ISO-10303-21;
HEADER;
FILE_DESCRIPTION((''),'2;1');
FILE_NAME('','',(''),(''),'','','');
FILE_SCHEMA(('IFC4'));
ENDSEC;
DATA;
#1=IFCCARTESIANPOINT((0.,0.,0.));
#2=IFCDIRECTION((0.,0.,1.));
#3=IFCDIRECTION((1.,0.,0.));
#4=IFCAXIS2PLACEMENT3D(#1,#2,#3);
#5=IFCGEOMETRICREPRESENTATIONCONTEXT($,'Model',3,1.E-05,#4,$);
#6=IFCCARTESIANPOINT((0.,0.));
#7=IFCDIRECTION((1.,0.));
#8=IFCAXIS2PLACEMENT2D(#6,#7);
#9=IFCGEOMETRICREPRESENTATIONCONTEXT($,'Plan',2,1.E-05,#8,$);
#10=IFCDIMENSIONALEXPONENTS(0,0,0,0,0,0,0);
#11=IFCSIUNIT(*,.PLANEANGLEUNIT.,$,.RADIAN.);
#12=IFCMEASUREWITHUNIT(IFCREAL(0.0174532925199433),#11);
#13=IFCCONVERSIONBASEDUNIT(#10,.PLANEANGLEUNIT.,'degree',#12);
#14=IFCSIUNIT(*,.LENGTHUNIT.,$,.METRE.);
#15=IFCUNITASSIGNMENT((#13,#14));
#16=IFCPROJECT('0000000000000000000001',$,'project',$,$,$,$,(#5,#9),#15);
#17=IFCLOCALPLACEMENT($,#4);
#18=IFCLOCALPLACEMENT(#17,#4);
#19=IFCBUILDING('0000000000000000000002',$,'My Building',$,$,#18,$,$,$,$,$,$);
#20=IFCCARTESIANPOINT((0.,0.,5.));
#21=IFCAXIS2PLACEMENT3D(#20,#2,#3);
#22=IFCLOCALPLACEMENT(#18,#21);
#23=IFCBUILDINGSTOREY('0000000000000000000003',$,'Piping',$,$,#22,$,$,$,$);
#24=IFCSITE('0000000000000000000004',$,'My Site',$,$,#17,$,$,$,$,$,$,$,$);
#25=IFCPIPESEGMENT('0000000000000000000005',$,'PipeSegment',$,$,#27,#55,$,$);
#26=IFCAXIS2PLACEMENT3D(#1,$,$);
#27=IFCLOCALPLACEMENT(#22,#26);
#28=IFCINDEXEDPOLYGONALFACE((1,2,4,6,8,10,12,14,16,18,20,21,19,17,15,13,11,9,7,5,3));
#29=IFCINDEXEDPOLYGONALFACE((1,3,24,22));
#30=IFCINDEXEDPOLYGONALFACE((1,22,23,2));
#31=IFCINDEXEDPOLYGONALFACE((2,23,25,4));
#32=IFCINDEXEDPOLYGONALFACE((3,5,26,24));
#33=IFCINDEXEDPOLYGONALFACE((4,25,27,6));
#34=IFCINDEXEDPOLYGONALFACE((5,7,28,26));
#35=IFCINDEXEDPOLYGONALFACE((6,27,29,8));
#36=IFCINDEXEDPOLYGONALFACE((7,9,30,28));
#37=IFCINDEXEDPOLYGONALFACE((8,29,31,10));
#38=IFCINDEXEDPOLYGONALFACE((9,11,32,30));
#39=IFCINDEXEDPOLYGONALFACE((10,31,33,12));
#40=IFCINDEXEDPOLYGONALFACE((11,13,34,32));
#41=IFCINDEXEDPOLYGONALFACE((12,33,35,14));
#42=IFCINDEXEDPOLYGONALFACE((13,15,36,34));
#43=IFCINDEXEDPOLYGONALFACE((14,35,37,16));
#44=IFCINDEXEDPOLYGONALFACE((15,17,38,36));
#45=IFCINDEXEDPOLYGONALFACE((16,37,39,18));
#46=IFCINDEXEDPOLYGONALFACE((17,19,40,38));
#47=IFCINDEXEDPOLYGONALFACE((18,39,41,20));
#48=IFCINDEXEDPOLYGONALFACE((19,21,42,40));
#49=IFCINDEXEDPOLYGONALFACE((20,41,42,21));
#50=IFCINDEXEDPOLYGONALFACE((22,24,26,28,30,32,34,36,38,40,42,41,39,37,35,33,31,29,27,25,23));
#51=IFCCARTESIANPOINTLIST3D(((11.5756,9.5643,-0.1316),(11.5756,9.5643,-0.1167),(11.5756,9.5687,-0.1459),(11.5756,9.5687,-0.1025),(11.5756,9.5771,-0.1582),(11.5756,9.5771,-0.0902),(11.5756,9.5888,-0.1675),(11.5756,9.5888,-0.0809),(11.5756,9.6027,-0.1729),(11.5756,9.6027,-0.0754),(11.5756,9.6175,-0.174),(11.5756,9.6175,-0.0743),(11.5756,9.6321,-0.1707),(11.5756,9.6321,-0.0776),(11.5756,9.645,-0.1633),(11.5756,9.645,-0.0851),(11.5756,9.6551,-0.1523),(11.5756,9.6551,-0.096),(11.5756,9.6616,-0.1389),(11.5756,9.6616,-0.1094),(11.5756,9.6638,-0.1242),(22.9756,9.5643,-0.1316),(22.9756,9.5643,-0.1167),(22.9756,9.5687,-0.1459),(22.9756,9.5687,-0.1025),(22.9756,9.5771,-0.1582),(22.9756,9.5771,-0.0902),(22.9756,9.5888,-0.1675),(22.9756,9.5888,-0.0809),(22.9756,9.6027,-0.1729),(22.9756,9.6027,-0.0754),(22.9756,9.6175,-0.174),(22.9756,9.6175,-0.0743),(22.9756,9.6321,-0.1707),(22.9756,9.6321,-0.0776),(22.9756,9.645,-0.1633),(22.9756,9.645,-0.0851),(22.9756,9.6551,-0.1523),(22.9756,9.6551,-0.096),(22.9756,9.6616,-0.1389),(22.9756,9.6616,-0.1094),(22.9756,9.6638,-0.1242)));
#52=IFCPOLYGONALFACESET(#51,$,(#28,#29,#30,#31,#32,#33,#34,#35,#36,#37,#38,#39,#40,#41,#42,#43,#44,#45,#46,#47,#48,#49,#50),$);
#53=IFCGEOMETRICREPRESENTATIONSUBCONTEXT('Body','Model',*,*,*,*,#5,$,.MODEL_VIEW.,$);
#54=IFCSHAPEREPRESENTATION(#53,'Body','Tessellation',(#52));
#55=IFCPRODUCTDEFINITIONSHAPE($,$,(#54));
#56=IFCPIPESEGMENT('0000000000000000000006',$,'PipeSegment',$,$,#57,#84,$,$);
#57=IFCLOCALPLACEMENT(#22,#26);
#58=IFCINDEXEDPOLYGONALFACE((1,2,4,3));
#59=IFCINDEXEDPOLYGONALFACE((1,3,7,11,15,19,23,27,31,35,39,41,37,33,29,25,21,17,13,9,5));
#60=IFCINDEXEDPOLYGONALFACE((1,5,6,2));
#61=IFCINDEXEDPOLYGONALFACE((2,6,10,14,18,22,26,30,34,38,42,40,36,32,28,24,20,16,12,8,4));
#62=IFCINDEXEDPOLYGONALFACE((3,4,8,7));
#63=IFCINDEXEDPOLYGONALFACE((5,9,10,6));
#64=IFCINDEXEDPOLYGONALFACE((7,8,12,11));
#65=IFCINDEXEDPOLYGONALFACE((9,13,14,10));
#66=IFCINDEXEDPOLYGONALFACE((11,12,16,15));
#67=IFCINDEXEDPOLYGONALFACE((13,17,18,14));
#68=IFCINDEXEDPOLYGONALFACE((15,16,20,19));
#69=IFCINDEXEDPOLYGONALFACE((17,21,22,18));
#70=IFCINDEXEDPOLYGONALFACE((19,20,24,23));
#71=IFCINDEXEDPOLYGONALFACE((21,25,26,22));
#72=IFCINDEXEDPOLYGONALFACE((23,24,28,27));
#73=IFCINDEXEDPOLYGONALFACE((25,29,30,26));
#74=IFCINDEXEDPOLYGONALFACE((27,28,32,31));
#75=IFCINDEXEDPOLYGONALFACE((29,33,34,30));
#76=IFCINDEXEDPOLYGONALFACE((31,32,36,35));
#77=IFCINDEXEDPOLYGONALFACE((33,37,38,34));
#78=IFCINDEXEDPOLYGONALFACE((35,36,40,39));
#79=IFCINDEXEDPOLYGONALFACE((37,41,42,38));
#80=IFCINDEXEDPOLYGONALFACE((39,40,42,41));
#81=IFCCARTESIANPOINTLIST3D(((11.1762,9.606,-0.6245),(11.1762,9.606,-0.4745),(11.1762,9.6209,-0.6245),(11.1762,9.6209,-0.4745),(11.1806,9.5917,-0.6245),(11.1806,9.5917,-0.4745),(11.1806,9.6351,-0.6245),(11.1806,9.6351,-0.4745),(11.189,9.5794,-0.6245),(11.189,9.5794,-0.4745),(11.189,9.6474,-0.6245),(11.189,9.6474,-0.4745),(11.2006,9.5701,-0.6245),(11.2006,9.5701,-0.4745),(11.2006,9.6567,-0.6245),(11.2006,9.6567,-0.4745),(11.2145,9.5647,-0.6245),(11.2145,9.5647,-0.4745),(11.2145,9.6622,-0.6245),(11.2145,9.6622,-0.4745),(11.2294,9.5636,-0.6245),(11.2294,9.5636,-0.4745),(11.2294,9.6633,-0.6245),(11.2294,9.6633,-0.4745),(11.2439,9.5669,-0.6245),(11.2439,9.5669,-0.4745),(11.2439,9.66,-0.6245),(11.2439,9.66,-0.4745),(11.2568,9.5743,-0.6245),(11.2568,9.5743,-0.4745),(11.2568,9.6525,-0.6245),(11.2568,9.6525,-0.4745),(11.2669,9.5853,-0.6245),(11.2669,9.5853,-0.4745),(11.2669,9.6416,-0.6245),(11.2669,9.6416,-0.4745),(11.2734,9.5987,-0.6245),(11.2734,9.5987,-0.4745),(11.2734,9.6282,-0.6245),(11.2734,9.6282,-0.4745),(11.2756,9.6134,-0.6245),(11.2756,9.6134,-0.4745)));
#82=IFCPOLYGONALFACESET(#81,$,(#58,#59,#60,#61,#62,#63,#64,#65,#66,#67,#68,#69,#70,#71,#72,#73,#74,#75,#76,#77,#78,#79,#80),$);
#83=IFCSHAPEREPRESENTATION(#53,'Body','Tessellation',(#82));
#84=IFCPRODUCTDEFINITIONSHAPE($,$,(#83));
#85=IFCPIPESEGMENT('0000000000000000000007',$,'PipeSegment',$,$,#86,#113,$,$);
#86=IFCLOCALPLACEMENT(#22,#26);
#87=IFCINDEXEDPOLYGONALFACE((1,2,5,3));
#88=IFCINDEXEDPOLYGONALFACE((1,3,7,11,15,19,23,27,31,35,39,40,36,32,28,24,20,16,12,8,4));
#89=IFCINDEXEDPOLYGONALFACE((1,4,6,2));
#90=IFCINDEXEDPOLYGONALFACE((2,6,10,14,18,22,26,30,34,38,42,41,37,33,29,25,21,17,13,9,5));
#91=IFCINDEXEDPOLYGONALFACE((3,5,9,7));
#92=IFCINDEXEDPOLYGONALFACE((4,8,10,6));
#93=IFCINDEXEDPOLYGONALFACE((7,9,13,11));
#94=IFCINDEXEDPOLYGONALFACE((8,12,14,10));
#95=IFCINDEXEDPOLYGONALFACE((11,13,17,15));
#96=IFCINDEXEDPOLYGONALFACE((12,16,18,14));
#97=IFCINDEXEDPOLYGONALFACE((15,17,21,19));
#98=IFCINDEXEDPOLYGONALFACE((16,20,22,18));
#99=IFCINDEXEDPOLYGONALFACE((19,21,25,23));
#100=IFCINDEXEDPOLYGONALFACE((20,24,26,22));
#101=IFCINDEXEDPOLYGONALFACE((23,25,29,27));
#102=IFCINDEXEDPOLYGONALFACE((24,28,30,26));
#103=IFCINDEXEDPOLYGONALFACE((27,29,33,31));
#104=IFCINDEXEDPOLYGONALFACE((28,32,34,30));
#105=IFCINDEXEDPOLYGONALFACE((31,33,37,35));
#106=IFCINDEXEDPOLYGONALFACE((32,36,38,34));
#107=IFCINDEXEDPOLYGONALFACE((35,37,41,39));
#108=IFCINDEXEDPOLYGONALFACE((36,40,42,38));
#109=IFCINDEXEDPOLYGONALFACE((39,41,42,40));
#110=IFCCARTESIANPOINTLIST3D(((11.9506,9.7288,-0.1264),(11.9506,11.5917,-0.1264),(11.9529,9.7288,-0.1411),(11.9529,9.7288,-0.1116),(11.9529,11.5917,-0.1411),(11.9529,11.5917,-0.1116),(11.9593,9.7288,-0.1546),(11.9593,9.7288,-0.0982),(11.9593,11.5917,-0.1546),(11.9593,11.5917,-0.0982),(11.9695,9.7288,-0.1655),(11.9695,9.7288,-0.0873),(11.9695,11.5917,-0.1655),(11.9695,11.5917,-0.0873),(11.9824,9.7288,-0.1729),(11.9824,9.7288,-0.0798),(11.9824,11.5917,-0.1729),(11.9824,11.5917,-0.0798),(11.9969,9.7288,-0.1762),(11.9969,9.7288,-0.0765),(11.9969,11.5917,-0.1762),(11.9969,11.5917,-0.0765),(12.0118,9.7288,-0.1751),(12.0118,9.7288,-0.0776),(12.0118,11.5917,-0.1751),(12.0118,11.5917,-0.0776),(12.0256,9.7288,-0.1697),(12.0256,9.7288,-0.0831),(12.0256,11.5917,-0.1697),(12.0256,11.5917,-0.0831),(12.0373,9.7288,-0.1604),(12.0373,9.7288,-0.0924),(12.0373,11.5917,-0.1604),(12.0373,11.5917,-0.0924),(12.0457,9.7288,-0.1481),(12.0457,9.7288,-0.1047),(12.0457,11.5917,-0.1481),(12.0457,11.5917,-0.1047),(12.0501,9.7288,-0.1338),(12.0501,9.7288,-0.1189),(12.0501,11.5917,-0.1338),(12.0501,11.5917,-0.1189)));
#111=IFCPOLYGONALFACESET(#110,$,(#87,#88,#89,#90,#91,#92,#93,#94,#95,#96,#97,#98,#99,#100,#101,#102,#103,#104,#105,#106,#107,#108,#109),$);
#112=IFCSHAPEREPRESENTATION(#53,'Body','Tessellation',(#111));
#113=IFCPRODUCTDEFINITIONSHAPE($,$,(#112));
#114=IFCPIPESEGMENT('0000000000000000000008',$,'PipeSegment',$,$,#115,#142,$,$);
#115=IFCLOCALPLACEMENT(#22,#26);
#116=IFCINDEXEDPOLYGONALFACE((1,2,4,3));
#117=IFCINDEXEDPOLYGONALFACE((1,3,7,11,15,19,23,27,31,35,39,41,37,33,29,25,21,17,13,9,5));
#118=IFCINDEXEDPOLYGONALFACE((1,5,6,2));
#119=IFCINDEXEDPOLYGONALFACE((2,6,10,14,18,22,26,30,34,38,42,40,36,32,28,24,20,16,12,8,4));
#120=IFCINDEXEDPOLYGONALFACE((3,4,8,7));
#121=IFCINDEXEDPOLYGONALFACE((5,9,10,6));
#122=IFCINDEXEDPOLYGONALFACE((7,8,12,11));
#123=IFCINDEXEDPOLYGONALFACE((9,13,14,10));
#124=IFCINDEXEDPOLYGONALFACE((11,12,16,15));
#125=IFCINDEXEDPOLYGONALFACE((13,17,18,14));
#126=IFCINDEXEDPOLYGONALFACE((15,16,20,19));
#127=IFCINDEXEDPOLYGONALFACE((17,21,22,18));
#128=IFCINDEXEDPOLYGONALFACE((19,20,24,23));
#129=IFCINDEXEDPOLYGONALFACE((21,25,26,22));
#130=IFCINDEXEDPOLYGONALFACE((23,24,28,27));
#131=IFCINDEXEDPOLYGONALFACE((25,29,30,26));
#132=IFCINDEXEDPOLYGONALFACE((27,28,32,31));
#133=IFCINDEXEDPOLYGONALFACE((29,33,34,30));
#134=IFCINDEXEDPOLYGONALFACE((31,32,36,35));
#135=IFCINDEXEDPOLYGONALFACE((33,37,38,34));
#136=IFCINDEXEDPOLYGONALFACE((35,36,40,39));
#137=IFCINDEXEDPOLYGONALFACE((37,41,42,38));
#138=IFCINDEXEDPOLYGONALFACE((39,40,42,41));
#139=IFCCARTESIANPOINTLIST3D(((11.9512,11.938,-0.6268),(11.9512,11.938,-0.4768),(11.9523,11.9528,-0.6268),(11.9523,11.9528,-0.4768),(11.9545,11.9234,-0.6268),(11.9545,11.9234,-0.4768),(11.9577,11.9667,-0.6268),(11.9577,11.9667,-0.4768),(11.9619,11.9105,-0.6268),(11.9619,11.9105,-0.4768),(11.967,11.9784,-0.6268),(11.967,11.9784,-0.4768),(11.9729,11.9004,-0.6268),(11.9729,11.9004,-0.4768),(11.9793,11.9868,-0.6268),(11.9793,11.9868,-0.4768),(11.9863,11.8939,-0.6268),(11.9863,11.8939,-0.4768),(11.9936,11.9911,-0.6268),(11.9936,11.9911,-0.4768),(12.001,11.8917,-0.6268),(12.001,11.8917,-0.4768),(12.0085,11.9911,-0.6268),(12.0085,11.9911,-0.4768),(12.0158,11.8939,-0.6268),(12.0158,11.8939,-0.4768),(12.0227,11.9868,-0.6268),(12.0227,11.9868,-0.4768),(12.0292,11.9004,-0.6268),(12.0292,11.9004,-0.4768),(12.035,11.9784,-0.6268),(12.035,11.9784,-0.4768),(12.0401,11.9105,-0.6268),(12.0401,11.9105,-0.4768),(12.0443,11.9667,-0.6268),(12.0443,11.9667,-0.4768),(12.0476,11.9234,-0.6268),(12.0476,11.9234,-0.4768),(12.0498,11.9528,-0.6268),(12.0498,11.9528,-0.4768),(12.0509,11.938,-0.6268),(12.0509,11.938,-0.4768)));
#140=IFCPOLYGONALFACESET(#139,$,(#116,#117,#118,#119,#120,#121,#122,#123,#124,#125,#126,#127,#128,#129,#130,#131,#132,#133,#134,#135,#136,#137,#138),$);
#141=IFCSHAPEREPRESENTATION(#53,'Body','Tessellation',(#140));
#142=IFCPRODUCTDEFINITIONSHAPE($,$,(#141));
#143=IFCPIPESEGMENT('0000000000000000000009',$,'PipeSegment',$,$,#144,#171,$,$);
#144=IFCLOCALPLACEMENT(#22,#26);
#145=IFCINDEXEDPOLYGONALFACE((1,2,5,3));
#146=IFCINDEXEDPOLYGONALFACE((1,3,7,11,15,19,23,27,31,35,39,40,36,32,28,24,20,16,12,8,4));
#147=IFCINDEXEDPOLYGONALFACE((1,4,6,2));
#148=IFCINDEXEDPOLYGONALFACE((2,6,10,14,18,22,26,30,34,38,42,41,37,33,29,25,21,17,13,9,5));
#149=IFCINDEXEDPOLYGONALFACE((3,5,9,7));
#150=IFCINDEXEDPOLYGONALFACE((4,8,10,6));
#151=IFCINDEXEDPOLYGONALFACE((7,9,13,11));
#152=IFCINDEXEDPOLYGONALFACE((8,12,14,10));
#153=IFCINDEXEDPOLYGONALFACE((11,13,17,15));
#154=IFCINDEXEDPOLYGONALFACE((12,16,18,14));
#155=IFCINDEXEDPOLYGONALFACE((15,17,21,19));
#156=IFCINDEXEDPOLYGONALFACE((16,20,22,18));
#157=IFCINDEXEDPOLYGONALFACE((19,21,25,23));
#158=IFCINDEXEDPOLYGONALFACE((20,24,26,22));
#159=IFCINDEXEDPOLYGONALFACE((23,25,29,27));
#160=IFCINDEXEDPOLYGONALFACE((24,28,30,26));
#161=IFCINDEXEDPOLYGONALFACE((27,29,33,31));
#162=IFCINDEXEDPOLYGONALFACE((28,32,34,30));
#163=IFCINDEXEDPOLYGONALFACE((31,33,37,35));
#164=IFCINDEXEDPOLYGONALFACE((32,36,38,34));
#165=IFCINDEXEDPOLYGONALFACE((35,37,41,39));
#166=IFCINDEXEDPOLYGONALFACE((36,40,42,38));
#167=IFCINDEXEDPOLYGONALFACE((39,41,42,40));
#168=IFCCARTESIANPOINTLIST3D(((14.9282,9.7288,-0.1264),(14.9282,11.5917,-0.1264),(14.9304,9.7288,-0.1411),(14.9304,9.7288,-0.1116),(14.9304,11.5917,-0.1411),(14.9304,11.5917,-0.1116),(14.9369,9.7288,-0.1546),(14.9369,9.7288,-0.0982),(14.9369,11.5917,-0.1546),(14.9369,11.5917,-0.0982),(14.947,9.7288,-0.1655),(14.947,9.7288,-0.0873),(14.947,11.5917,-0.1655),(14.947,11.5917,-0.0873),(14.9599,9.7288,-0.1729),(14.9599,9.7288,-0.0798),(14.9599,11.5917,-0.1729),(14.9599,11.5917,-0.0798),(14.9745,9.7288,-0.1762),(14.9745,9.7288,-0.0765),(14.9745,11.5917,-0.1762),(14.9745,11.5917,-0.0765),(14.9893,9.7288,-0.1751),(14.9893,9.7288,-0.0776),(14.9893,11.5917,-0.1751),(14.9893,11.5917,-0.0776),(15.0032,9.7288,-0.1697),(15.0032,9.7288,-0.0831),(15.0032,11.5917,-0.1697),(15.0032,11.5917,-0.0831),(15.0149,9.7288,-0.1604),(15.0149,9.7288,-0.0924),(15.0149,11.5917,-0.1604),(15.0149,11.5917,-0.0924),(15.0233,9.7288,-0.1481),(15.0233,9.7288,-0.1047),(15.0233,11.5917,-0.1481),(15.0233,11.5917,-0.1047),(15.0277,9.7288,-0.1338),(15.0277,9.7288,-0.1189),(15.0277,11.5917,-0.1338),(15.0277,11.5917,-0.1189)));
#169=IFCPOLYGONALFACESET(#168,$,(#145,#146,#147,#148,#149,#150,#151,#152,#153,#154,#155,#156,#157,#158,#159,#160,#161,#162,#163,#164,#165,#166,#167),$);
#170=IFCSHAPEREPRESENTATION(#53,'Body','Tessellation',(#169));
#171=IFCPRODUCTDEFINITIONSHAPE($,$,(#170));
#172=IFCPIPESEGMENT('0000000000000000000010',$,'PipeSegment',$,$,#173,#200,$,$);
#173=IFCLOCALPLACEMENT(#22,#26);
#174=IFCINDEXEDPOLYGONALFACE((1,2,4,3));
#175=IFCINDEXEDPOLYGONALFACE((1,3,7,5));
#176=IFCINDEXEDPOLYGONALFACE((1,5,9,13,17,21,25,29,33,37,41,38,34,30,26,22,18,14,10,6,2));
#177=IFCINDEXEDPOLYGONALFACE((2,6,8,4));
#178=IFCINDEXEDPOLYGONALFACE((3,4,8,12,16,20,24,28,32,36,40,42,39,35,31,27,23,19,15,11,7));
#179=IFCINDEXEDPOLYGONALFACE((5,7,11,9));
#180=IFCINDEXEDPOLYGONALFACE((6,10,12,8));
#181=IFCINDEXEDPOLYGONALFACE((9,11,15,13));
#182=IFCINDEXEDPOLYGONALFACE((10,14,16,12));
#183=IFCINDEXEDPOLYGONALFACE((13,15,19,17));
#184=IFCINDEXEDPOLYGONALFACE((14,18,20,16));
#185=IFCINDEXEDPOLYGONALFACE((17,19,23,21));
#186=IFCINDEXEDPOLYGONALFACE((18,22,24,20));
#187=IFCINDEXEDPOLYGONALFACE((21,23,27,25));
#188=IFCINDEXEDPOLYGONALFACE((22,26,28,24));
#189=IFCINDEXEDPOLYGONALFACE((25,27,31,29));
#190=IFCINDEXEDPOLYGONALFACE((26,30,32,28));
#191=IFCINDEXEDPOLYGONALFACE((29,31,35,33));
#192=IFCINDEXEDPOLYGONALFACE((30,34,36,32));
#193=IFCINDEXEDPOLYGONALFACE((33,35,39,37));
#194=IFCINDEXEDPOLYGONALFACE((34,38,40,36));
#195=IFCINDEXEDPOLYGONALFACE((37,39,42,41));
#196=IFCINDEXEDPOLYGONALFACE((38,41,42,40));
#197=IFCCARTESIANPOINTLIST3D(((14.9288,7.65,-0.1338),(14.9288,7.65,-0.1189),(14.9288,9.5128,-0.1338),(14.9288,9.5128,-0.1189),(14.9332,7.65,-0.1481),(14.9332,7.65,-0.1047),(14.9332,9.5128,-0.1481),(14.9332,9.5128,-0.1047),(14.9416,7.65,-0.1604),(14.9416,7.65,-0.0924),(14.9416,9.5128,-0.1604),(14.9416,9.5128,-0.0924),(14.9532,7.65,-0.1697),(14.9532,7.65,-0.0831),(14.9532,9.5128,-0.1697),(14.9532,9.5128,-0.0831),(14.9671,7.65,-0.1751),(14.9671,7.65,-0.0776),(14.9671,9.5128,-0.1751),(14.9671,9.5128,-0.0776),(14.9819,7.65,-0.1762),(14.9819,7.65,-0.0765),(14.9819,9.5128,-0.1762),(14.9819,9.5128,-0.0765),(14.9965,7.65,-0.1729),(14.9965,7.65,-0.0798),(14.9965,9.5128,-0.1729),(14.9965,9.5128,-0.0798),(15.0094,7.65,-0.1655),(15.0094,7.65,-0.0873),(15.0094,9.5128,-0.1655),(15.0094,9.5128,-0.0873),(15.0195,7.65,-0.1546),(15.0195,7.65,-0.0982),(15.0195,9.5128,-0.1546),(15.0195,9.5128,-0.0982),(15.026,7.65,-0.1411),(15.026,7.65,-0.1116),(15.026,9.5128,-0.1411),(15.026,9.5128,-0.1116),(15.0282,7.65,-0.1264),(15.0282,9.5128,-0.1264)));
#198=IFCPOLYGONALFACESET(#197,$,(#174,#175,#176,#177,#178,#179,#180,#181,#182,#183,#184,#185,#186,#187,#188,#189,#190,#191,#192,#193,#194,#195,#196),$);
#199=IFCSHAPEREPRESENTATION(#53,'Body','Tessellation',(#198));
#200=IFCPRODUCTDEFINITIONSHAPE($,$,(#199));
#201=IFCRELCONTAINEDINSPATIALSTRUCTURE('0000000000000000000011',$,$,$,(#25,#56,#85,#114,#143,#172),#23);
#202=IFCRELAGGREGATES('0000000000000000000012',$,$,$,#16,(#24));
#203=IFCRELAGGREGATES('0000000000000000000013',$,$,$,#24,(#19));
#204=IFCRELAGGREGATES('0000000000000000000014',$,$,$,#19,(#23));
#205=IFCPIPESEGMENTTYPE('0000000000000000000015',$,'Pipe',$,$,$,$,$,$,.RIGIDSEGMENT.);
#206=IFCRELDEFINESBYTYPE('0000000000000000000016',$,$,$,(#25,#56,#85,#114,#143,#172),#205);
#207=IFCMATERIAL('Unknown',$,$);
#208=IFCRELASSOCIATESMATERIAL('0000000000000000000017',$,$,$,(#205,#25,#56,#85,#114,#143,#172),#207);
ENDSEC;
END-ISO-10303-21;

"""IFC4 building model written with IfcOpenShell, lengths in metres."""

from ifc_helpers import new_model, entity, si_unit, converted_unit, frame, origin_with_axes, origin_2d_with_axis, place, context, subcontext, project, spatial, circle, extrude, material, material_profile, profile_set, profile_usage, type_object, element, save


model = new_model("IFC4")

# Units and contexts
model_context = context("Model", 3, precision=1e-05, world=origin_with_axes())
plan_context = context("Plan", 2, precision=1e-05, world=origin_2d_with_axis())
body_context = subcontext(model_context, "Body", "Model", "MODEL_VIEW")
ifc_project = project(units=[converted_unit("PLANEANGLEUNIT", "degree", entity("IfcReal", 0.0174532925199433), si_unit("PLANEANGLEUNIT", "RADIAN"), dimensions=[0, 0, 0, 0, 0, 0, 0]), si_unit("LENGTHUNIT", "METRE")], contexts=[model_context, plan_context])

# Site, building, storey
site_placement = place(None, origin_with_axes())
site = spatial("IfcSite", under=ifc_project, at=site_placement, Name="My Site")
building_placement = place(site_placement, origin_with_axes())
building = spatial("IfcBuilding", under=site, at=building_placement, Name="My Building")
storey_placement = place(building_placement, frame((0.0, 0.0, 5.0), z_axis=(0.0, 0.0, 1.0), x_axis=(1.0, 0.0, 0.0)))
storey = spatial("IfcBuildingStorey", under=building, at=storey_placement, Name="Piping")

# Pipe segments
ifc_material = material(Name="Unknown")
ifc_material_profile_1 = material_profile(ifc_material, circle(Radius=0.05))
ifc_profile_set_1 = profile_set([ifc_material_profile_1])
pipe_segment_type = type_object("IfcPipeSegmentType", Name="Pipe", PredefinedType="RIGIDSEGMENT", material=ifc_profile_set_1)
ifc_profile_usage_1 = profile_usage(ifc_profile_set_1, cardinal=5)
pipe_segment_1_placement = place(storey_placement, frame((11.5756, 9.6138, -0.1242), z_axis=(1.0, 0.0, 0.0), x_axis=(0.0, 1.0, 0.0)))
element("IfcPipeSegment", 1, at=pipe_segment_1_placement, inside=storey, type_object=pipe_segment_type, material=ifc_profile_usage_1, Name="PipeSegment", context=body_context, shape_type="SweptSolid", body=[
    extrude(circle(Radius=0.05), origin_with_axes(), (0.0, 0.0, 1.0), 11.4),
])
ifc_profile_usage_2 = profile_usage(ifc_profile_set_1, cardinal=5)
pipe_segment_2_placement = place(storey_placement, frame((11.2256, 9.6134, -0.4745), z_axis=(0.0, 0.0, -1.0), x_axis=(1.0, 0.0, 0.0)))
element("IfcPipeSegment", 2, at=pipe_segment_2_placement, inside=storey, type_object=pipe_segment_type, material=ifc_profile_usage_2, Name="PipeSegment", context=body_context, shape_type="SweptSolid", body=[
    extrude(circle(Radius=0.05), origin_with_axes(), (0.0, 0.0, 1.0), 0.15),
])
ifc_profile_usage_3 = profile_usage(ifc_profile_set_1, cardinal=5)
pipe_segment_3_placement = place(storey_placement, frame((12.0006, 9.7288, -0.1264), z_axis=(0.0, 1.0, 0.0), x_axis=(-1.0, 0.0, 0.0)))
element("IfcPipeSegment", 3, at=pipe_segment_3_placement, inside=storey, type_object=pipe_segment_type, material=ifc_profile_usage_3, Name="PipeSegment", context=body_context, shape_type="SweptSolid", body=[
    extrude(circle(Radius=0.05), origin_with_axes(), (0.0, 0.0, 1.0), 1.8629),
])
ifc_profile_usage_4 = profile_usage(ifc_profile_set_1, cardinal=5)
pipe_segment_4_placement = place(storey_placement, frame((12.001, 11.9417, -0.4768), z_axis=(0.0, 0.0, -1.0), x_axis=(-0.000053, -1.0, 0.0)))
element("IfcPipeSegment", 4, at=pipe_segment_4_placement, inside=storey, type_object=pipe_segment_type, material=ifc_profile_usage_4, Name="PipeSegment", context=body_context, shape_type="SweptSolid", body=[
    extrude(circle(Radius=0.05), origin_with_axes(), (0.0, 0.0, 1.0), 0.15),
])
ifc_profile_usage_5 = profile_usage(ifc_profile_set_1, cardinal=5)
pipe_segment_5_placement = place(storey_placement, frame((14.9782, 9.7288, -0.1264), z_axis=(0.0, 1.0, 0.0), x_axis=(-1.0, 0.0, 0.0)))
element("IfcPipeSegment", 5, at=pipe_segment_5_placement, inside=storey, type_object=pipe_segment_type, material=ifc_profile_usage_5, Name="PipeSegment", context=body_context, shape_type="SweptSolid", body=[
    extrude(circle(Radius=0.05), origin_with_axes(), (0.0, 0.0, 1.0), 1.8629),
])
ifc_profile_usage_6 = profile_usage(ifc_profile_set_1, cardinal=5)
pipe_segment_6_placement = place(storey_placement, frame((14.9782, 9.5128, -0.1264), z_axis=(0.0, -1.0, 0.0), x_axis=(1.0, 0.0, 0.0)))
element("IfcPipeSegment", 6, at=pipe_segment_6_placement, inside=storey, type_object=pipe_segment_type, material=ifc_profile_usage_6, Name="PipeSegment", context=body_context, shape_type="SweptSolid", body=[
    extrude(circle(Radius=0.05), origin_with_axes(), (0.0, 0.0, 1.0), 1.8629),
])

save(model, "model.ifc")
